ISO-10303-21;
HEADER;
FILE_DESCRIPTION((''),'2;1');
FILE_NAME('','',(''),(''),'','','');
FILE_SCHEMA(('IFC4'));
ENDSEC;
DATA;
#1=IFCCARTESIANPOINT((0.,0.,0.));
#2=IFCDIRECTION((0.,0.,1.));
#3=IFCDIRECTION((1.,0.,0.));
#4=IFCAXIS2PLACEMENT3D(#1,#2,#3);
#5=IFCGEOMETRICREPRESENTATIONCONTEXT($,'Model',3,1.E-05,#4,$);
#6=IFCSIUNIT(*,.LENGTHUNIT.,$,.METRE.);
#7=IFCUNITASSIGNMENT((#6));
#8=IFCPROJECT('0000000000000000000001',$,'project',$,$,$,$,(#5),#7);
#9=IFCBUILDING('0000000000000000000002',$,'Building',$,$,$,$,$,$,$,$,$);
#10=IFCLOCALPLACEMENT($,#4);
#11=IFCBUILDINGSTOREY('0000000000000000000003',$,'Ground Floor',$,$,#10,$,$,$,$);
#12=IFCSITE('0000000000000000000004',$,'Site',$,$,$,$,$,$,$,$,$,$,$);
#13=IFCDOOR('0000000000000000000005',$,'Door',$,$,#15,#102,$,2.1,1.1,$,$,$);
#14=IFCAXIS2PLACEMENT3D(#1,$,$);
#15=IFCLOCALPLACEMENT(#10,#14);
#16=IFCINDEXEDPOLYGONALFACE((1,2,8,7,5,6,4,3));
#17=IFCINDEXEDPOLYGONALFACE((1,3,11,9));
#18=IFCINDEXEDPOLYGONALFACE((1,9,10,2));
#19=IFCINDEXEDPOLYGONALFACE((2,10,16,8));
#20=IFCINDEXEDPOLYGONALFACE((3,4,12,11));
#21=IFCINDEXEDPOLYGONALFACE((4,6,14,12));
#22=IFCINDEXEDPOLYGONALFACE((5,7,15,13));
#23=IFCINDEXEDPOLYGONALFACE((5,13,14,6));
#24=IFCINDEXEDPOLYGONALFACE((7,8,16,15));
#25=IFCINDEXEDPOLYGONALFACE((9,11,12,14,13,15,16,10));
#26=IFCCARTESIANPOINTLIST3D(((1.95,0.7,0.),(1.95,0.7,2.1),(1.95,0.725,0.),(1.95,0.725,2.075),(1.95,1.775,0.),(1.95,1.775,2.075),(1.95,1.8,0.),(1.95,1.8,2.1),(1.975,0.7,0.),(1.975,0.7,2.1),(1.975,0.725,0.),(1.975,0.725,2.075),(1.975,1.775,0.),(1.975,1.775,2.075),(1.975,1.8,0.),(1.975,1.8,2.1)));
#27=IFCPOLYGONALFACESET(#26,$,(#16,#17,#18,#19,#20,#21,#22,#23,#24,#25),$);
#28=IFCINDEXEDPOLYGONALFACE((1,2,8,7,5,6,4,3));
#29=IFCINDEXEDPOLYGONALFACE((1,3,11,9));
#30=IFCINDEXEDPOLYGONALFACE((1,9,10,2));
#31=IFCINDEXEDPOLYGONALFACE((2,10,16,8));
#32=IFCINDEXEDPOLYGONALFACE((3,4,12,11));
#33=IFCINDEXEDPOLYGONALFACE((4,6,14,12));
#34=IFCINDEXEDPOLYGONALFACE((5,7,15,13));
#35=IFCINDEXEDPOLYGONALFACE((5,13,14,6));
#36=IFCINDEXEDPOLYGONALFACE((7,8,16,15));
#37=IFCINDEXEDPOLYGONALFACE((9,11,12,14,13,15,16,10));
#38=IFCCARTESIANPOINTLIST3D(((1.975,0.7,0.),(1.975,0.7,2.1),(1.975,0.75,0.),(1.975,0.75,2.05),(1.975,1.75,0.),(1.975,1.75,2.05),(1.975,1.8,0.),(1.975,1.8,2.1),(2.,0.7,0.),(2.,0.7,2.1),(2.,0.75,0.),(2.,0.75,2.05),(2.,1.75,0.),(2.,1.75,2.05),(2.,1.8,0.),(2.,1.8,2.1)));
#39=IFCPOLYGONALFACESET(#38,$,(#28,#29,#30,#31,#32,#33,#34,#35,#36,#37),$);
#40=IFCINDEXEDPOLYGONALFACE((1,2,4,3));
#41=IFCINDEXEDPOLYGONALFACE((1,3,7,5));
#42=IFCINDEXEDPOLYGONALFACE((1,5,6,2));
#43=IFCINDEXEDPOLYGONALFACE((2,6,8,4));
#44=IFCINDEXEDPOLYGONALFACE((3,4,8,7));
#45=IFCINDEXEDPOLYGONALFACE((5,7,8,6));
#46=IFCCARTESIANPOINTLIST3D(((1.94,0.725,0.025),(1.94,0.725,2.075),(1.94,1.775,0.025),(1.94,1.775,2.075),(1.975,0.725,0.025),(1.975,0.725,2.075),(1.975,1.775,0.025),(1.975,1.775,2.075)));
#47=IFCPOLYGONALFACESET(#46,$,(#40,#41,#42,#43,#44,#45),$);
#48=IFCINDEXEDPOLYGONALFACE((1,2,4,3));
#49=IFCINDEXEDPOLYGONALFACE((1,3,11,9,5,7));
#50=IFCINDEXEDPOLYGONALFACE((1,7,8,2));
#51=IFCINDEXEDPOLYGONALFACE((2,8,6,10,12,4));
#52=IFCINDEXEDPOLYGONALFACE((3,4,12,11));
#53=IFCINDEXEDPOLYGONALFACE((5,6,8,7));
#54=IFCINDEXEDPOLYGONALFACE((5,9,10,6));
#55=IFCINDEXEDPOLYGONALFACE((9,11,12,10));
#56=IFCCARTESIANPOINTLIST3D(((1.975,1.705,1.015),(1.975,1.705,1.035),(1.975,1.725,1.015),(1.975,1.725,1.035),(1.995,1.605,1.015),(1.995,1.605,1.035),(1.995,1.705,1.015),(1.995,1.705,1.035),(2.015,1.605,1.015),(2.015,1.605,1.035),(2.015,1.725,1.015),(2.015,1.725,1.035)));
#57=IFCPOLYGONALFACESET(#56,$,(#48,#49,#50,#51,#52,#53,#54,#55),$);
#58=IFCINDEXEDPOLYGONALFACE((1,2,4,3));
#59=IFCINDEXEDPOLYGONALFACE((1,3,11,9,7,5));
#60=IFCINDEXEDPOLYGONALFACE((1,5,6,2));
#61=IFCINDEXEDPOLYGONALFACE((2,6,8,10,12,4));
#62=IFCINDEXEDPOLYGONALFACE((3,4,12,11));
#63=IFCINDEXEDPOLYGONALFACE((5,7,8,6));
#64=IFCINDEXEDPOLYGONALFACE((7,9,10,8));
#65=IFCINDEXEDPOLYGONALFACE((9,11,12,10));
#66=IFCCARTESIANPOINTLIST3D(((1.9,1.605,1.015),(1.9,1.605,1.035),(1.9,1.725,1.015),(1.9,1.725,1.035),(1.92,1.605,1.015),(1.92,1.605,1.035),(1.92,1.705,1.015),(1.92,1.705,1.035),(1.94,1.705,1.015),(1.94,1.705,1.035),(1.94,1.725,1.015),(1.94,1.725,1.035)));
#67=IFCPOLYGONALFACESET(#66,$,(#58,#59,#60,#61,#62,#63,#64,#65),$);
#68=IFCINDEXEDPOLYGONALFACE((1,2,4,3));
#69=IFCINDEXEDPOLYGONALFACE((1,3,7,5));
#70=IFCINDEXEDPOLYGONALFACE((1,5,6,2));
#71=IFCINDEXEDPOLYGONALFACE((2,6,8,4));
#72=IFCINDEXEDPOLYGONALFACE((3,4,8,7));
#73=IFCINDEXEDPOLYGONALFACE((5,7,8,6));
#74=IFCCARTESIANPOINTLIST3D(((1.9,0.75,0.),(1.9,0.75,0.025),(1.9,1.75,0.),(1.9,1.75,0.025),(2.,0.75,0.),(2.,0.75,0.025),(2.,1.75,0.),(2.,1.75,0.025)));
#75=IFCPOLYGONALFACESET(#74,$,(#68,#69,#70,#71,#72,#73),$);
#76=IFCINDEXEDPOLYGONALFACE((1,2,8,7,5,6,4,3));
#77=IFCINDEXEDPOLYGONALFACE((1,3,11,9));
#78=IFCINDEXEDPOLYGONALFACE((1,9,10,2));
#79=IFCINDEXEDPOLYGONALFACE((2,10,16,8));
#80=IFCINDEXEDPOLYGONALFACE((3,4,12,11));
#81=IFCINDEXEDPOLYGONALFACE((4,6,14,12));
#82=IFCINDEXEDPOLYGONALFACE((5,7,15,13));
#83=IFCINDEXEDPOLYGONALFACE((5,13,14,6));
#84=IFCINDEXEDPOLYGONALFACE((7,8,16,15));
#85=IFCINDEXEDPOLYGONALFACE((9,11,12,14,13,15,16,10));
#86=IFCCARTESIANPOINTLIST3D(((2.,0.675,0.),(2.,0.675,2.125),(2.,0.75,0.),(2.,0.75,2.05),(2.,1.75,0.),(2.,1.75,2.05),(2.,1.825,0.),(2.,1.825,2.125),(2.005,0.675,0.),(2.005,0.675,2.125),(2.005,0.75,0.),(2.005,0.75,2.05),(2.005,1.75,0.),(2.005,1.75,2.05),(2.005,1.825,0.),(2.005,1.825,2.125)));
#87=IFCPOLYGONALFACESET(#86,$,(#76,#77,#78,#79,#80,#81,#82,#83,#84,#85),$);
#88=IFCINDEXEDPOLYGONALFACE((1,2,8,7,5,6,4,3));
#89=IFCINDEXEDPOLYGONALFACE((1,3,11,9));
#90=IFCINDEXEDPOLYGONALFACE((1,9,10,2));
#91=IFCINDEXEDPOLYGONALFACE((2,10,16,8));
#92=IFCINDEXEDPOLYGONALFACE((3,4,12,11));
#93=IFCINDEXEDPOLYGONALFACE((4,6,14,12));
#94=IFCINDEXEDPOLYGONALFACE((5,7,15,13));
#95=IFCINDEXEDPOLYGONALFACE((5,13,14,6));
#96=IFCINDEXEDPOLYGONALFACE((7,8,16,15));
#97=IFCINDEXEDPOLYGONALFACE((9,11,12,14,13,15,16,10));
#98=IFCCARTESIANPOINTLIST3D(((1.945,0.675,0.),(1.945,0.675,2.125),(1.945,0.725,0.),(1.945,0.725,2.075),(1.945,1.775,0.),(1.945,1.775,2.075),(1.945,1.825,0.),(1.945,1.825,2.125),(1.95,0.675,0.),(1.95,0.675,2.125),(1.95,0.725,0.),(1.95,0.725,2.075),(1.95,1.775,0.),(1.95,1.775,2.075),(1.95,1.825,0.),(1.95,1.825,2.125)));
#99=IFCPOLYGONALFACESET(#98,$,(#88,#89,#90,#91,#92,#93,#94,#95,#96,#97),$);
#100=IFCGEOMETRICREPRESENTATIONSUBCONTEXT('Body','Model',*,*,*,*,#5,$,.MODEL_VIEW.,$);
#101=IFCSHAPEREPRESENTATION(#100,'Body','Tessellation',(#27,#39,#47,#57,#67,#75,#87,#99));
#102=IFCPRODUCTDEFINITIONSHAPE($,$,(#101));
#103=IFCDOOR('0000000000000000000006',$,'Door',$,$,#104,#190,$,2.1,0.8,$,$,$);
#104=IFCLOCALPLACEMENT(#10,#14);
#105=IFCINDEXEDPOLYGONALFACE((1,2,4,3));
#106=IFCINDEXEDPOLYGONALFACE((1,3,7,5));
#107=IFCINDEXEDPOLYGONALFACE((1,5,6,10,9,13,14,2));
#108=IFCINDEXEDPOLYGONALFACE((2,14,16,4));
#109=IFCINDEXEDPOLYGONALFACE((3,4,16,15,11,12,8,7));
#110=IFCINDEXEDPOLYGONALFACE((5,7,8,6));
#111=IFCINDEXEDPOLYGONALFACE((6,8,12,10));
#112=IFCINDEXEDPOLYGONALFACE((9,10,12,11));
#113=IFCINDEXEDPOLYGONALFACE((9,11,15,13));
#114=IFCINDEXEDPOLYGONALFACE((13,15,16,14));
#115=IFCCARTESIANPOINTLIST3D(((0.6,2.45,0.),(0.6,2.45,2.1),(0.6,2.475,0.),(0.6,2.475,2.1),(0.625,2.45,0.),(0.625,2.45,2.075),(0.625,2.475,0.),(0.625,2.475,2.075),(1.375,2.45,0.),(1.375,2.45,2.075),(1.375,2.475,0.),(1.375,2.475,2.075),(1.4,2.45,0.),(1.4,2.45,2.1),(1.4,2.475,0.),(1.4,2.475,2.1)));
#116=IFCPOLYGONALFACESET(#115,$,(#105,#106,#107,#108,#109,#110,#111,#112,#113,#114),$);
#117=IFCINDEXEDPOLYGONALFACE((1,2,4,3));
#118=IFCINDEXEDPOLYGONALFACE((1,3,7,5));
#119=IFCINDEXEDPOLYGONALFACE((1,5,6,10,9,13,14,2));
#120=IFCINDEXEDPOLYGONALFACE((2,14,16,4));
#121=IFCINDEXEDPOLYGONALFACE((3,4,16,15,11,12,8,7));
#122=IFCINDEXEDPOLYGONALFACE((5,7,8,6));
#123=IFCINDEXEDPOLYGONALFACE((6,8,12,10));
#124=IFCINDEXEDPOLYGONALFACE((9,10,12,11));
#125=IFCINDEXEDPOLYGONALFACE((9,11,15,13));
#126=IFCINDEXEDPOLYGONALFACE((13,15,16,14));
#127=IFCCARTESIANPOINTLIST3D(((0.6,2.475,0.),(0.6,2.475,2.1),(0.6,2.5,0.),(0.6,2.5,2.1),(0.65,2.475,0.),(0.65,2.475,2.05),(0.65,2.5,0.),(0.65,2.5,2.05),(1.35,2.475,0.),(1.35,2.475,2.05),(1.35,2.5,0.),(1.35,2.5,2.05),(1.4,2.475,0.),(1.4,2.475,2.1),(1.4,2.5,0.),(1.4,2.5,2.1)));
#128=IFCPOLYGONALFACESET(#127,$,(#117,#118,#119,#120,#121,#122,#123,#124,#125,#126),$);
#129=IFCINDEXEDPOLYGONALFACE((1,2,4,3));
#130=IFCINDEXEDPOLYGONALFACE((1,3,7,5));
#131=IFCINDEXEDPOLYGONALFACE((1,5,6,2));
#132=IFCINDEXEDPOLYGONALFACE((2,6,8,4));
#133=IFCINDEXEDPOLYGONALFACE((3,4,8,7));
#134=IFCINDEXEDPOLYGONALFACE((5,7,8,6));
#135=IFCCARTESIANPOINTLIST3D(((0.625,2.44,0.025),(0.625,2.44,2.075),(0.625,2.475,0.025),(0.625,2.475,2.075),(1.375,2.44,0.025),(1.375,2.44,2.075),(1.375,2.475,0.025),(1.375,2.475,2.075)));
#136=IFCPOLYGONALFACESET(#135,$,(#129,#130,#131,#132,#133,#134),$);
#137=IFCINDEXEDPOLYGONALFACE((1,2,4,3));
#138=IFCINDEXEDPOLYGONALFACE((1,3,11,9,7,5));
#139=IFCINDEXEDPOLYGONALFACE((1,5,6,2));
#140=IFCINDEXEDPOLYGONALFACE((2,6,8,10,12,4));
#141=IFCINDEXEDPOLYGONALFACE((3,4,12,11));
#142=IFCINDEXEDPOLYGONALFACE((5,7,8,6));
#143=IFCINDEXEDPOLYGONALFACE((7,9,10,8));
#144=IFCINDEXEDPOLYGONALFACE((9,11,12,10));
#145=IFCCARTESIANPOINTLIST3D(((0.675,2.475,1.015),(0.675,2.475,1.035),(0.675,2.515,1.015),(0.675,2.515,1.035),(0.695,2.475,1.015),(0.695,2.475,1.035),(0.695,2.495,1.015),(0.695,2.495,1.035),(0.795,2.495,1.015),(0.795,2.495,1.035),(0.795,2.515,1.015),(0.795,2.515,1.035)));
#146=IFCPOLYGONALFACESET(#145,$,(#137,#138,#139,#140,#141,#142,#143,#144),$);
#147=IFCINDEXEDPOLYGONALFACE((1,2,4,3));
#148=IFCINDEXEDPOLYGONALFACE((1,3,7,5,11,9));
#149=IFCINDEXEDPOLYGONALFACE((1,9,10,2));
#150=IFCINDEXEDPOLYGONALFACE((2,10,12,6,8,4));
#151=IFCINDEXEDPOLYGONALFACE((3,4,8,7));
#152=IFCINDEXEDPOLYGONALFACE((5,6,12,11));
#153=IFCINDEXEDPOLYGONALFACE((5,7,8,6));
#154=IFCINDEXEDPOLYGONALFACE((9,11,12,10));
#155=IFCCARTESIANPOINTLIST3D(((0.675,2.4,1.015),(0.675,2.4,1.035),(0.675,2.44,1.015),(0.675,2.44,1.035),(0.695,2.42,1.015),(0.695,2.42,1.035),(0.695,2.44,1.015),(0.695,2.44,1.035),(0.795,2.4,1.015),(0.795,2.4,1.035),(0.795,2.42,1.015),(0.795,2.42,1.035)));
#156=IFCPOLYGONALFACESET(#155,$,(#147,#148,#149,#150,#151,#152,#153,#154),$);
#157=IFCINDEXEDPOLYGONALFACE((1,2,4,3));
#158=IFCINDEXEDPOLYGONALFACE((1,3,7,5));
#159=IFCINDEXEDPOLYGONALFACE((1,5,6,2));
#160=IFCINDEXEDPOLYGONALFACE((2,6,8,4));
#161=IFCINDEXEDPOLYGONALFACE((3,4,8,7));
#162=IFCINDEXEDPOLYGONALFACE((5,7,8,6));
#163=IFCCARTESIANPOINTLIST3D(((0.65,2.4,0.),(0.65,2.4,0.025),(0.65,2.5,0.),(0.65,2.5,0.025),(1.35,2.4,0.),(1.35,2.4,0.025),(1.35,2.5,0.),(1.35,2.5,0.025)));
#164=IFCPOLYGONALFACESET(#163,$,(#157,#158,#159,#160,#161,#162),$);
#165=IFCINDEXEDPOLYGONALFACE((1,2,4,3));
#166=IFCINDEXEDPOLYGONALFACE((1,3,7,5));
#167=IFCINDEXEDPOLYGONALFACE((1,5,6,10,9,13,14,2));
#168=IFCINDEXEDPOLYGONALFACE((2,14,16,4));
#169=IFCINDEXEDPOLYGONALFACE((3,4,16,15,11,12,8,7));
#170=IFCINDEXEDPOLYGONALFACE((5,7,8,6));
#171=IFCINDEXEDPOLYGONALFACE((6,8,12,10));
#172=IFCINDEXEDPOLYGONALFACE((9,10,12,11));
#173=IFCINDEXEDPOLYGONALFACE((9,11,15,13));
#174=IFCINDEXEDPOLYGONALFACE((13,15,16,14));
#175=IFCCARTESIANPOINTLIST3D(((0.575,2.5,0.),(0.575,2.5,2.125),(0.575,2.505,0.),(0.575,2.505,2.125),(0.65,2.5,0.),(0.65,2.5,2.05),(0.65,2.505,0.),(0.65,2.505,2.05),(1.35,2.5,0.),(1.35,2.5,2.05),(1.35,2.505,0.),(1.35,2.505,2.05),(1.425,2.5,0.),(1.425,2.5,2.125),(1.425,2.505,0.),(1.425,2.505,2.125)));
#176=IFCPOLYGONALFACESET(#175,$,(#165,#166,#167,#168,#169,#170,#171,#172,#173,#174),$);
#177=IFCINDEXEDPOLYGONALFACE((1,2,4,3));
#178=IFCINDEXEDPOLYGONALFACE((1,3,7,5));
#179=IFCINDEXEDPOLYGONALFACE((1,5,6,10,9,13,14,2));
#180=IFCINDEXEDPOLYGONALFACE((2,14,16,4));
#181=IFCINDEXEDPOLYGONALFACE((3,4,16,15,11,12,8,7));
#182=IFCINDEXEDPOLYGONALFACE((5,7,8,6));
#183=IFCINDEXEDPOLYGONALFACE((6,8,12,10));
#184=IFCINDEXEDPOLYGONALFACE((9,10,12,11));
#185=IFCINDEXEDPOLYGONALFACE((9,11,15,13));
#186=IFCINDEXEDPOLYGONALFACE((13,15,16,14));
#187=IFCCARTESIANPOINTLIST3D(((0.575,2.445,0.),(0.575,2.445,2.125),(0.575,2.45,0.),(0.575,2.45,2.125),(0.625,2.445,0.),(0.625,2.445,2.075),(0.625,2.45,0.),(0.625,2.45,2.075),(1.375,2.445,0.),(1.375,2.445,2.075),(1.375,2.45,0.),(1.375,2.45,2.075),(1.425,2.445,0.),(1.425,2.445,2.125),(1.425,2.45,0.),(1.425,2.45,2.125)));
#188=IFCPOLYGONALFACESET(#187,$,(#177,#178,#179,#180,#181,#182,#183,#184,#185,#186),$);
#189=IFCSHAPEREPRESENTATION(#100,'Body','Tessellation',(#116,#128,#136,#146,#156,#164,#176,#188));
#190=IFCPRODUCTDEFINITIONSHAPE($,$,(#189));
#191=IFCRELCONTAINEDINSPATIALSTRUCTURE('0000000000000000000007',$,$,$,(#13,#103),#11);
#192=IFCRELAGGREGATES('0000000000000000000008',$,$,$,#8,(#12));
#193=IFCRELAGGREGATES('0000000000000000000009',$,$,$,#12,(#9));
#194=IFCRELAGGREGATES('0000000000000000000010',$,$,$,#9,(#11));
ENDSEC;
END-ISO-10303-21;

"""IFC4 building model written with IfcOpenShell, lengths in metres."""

from ifc_helpers import new_model, si_unit, frame, origin_with_axes, place, context, subcontext, project, spatial, line, indexed_curve, outline, extrude, element, save


model = new_model("IFC4")

# Units and contexts
model_context = context("Model", 3, precision=1e-05, world=origin_with_axes())
body_context = subcontext(model_context, "Body", "Model", "MODEL_VIEW")
ifc_project = project(units=[si_unit("LENGTHUNIT", "METRE")], contexts=[model_context])

# Site, building, storey
site = spatial("IfcSite", under=ifc_project, Name="Site")
building = spatial("IfcBuilding", under=site, Name="Building")
storey_placement = place(None, origin_with_axes())
storey = spatial("IfcBuildingStorey", under=building, at=storey_placement, Name="Ground Floor")

# Doors
door_1_placement = place(storey_placement, frame((2.0, 0.7, 0.0), z_axis=(0.0, 0.0, 1.0), x_axis=(0.0, 1.0, 0.0)))
element("IfcDoor", 1, at=door_1_placement, inside=storey, Name="Door", OverallHeight=2.1, OverallWidth=1.1, context=body_context, shape_type="SweptSolid", body=[
    extrude(outline(indexed_curve([(0.0, 0.0), (0.0, 2.1), (1.1, 2.1), (1.1, 0.0), (1.075, 0.0), (1.075, 2.075), (0.025, 2.075), (0.025, 0.0)], segments=[line(1, 2, 3, 4, 5, 6, 7, 8, 1)])), frame((0.0, 0.025, 0.0), z_axis=(0.0, -1.0, 0.0), x_axis=(1.0, 0.0, 0.0)), (0.0, 0.0, -1.0), 0.025),
    extrude(outline(indexed_curve([(0.0, 0.0), (0.0, 2.1), (1.1, 2.1), (1.1, 0.0), (1.05, 0.0), (1.05, 2.05), (0.05, 2.05), (0.05, 0.0)], segments=[line(1, 2, 3, 4, 5, 6, 7, 8, 1)])), frame((0.0, 0.0, 0.0), z_axis=(0.0, -1.0, 0.0), x_axis=(1.0, 0.0, 0.0)), (0.0, 0.0, -1.0), 0.025),
    extrude(outline(indexed_curve([(0.0, 0.0), (1.05, 0.0), (1.05, 0.035), (0.0, 0.035)], segments=[line(1, 2, 3, 4, 1)])), frame((0.025, 0.025, 0.025), z_axis=(0.0, 0.0, 1.0), x_axis=(1.0, 0.0, 0.0)), (0.0, 0.0, 1.0), 2.05),
    extrude(outline(indexed_curve([(0.0, 0.0), (0.0, -0.04), (-0.12, -0.04), (-0.12, -0.02), (-0.02, -0.02), (-0.02, 0.0)], segments=[line(1, 2, 3, 4, 5, 6, 1)])), frame((1.025, 0.025, 1.015), z_axis=(0.0, 0.0, 1.0), x_axis=(1.0, 0.0, 0.0)), (0.0, 0.0, 1.0), 0.02),
    extrude(outline(indexed_curve([(0.0, 0.0), (0.0, 0.04), (-0.12, 0.04), (-0.12, 0.02), (-0.02, 0.02), (-0.02, 0.0)], segments=[line(1, 2, 3, 4, 5, 6, 1)])), frame((1.025, 0.06, 1.015), z_axis=(0.0, 0.0, 1.0), x_axis=(1.0, 0.0, 0.0)), (0.0, 0.0, 1.0), 0.02),
    extrude(outline(indexed_curve([(0.0, 0.0), (1.0, 0.0), (1.0, 0.1), (0.0, 0.1)], segments=[line(1, 2, 3, 4, 1)])), frame((0.05, 0.0, 0.0), z_axis=(0.0, 0.0, 1.0), x_axis=(1.0, 0.0, 0.0)), (0.0, 0.0, 1.0), 0.025),
    extrude(outline(indexed_curve([(0.0, 0.0), (0.0, 2.125), (1.15, 2.125), (1.15, 0.0), (1.075, 0.0), (1.075, 2.05), (0.075, 2.05), (0.075, 0.0)], segments=[line(1, 2, 3, 4, 5, 6, 7, 8, 1)])), frame((-0.025, -0.005, 0.0), z_axis=(0.0, -1.0, 0.0), x_axis=(1.0, 0.0, 0.0)), (0.0, 0.0, -1.0), 0.005),
    extrude(outline(indexed_curve([(0.0, 0.0), (0.0, 2.125), (1.15, 2.125), (1.15, 0.0), (1.1, 0.0), (1.1, 2.075), (0.05, 2.075), (0.05, 0.0)], segments=[line(1, 2, 3, 4, 5, 6, 7, 8, 1)])), frame((-0.025, 0.05, 0.0), z_axis=(0.0, -1.0, 0.0), x_axis=(1.0, 0.0, 0.0)), (0.0, 0.0, -1.0), 0.005),
])
door_2_placement = place(storey_placement, frame((1.4, 2.5, 0.0), z_axis=(0.0, 0.0, 1.0), x_axis=(-1.0, 0.0, 0.0)))
element("IfcDoor", 2, at=door_2_placement, inside=storey, Name="Door", OverallHeight=2.1, OverallWidth=0.8, context=body_context, shape_type="SweptSolid", body=[
    extrude(outline(indexed_curve([(0.0, 0.0), (0.0, 2.1), (0.8, 2.1), (0.8, 0.0), (0.775, 0.0), (0.775, 2.075), (0.025, 2.075), (0.025, 0.0)], segments=[line(1, 2, 3, 4, 5, 6, 7, 8, 1)])), frame((0.0, 0.025, 0.0), z_axis=(0.0, -1.0, 0.0), x_axis=(1.0, 0.0, 0.0)), (0.0, 0.0, -1.0), 0.025),
    extrude(outline(indexed_curve([(0.0, 0.0), (0.0, 2.1), (0.8, 2.1), (0.8, 0.0), (0.75, 0.0), (0.75, 2.05), (0.05, 2.05), (0.05, 0.0)], segments=[line(1, 2, 3, 4, 5, 6, 7, 8, 1)])), frame((0.0, 0.0, 0.0), z_axis=(0.0, -1.0, 0.0), x_axis=(1.0, 0.0, 0.0)), (0.0, 0.0, -1.0), 0.025),
    extrude(outline(indexed_curve([(0.0, 0.0), (0.75, 0.0), (0.75, 0.035), (0.0, 0.035)], segments=[line(1, 2, 3, 4, 1)])), frame((0.025, 0.025, 0.025), z_axis=(0.0, 0.0, 1.0), x_axis=(1.0, 0.0, 0.0)), (0.0, 0.0, 1.0), 2.05),
    extrude(outline(indexed_curve([(0.0, 0.0), (0.0, -0.04), (-0.12, -0.04), (-0.12, -0.02), (-0.02, -0.02), (-0.02, 0.0)], segments=[line(1, 2, 3, 4, 5, 6, 1)])), frame((0.725, 0.025, 1.015), z_axis=(0.0, 0.0, 1.0), x_axis=(1.0, 0.0, 0.0)), (0.0, 0.0, 1.0), 0.02),
    extrude(outline(indexed_curve([(0.0, 0.0), (0.0, 0.04), (-0.12, 0.04), (-0.12, 0.02), (-0.02, 0.02), (-0.02, 0.0)], segments=[line(1, 2, 3, 4, 5, 6, 1)])), frame((0.725, 0.06, 1.015), z_axis=(0.0, 0.0, 1.0), x_axis=(1.0, 0.0, 0.0)), (0.0, 0.0, 1.0), 0.02),
    extrude(outline(indexed_curve([(0.0, 0.0), (0.7, 0.0), (0.7, 0.1), (0.0, 0.1)], segments=[line(1, 2, 3, 4, 1)])), frame((0.05, 0.0, 0.0), z_axis=(0.0, 0.0, 1.0), x_axis=(1.0, 0.0, 0.0)), (0.0, 0.0, 1.0), 0.025),
    extrude(outline(indexed_curve([(0.0, 0.0), (0.0, 2.125), (0.85, 2.125), (0.85, 0.0), (0.775, 0.0), (0.775, 2.05), (0.075, 2.05), (0.075, 0.0)], segments=[line(1, 2, 3, 4, 5, 6, 7, 8, 1)])), frame((-0.025, -0.005, 0.0), z_axis=(0.0, -1.0, 0.0), x_axis=(1.0, 0.0, 0.0)), (0.0, 0.0, -1.0), 0.005),
    extrude(outline(indexed_curve([(0.0, 0.0), (0.0, 2.125), (0.85, 2.125), (0.85, 0.0), (0.8, 0.0), (0.8, 2.075), (0.05, 2.075), (0.05, 0.0)], segments=[line(1, 2, 3, 4, 5, 6, 7, 8, 1)])), frame((-0.025, 0.05, 0.0), z_axis=(0.0, -1.0, 0.0), x_axis=(1.0, 0.0, 0.0)), (0.0, 0.0, -1.0), 0.005),
])

save(model, "model.ifc")
